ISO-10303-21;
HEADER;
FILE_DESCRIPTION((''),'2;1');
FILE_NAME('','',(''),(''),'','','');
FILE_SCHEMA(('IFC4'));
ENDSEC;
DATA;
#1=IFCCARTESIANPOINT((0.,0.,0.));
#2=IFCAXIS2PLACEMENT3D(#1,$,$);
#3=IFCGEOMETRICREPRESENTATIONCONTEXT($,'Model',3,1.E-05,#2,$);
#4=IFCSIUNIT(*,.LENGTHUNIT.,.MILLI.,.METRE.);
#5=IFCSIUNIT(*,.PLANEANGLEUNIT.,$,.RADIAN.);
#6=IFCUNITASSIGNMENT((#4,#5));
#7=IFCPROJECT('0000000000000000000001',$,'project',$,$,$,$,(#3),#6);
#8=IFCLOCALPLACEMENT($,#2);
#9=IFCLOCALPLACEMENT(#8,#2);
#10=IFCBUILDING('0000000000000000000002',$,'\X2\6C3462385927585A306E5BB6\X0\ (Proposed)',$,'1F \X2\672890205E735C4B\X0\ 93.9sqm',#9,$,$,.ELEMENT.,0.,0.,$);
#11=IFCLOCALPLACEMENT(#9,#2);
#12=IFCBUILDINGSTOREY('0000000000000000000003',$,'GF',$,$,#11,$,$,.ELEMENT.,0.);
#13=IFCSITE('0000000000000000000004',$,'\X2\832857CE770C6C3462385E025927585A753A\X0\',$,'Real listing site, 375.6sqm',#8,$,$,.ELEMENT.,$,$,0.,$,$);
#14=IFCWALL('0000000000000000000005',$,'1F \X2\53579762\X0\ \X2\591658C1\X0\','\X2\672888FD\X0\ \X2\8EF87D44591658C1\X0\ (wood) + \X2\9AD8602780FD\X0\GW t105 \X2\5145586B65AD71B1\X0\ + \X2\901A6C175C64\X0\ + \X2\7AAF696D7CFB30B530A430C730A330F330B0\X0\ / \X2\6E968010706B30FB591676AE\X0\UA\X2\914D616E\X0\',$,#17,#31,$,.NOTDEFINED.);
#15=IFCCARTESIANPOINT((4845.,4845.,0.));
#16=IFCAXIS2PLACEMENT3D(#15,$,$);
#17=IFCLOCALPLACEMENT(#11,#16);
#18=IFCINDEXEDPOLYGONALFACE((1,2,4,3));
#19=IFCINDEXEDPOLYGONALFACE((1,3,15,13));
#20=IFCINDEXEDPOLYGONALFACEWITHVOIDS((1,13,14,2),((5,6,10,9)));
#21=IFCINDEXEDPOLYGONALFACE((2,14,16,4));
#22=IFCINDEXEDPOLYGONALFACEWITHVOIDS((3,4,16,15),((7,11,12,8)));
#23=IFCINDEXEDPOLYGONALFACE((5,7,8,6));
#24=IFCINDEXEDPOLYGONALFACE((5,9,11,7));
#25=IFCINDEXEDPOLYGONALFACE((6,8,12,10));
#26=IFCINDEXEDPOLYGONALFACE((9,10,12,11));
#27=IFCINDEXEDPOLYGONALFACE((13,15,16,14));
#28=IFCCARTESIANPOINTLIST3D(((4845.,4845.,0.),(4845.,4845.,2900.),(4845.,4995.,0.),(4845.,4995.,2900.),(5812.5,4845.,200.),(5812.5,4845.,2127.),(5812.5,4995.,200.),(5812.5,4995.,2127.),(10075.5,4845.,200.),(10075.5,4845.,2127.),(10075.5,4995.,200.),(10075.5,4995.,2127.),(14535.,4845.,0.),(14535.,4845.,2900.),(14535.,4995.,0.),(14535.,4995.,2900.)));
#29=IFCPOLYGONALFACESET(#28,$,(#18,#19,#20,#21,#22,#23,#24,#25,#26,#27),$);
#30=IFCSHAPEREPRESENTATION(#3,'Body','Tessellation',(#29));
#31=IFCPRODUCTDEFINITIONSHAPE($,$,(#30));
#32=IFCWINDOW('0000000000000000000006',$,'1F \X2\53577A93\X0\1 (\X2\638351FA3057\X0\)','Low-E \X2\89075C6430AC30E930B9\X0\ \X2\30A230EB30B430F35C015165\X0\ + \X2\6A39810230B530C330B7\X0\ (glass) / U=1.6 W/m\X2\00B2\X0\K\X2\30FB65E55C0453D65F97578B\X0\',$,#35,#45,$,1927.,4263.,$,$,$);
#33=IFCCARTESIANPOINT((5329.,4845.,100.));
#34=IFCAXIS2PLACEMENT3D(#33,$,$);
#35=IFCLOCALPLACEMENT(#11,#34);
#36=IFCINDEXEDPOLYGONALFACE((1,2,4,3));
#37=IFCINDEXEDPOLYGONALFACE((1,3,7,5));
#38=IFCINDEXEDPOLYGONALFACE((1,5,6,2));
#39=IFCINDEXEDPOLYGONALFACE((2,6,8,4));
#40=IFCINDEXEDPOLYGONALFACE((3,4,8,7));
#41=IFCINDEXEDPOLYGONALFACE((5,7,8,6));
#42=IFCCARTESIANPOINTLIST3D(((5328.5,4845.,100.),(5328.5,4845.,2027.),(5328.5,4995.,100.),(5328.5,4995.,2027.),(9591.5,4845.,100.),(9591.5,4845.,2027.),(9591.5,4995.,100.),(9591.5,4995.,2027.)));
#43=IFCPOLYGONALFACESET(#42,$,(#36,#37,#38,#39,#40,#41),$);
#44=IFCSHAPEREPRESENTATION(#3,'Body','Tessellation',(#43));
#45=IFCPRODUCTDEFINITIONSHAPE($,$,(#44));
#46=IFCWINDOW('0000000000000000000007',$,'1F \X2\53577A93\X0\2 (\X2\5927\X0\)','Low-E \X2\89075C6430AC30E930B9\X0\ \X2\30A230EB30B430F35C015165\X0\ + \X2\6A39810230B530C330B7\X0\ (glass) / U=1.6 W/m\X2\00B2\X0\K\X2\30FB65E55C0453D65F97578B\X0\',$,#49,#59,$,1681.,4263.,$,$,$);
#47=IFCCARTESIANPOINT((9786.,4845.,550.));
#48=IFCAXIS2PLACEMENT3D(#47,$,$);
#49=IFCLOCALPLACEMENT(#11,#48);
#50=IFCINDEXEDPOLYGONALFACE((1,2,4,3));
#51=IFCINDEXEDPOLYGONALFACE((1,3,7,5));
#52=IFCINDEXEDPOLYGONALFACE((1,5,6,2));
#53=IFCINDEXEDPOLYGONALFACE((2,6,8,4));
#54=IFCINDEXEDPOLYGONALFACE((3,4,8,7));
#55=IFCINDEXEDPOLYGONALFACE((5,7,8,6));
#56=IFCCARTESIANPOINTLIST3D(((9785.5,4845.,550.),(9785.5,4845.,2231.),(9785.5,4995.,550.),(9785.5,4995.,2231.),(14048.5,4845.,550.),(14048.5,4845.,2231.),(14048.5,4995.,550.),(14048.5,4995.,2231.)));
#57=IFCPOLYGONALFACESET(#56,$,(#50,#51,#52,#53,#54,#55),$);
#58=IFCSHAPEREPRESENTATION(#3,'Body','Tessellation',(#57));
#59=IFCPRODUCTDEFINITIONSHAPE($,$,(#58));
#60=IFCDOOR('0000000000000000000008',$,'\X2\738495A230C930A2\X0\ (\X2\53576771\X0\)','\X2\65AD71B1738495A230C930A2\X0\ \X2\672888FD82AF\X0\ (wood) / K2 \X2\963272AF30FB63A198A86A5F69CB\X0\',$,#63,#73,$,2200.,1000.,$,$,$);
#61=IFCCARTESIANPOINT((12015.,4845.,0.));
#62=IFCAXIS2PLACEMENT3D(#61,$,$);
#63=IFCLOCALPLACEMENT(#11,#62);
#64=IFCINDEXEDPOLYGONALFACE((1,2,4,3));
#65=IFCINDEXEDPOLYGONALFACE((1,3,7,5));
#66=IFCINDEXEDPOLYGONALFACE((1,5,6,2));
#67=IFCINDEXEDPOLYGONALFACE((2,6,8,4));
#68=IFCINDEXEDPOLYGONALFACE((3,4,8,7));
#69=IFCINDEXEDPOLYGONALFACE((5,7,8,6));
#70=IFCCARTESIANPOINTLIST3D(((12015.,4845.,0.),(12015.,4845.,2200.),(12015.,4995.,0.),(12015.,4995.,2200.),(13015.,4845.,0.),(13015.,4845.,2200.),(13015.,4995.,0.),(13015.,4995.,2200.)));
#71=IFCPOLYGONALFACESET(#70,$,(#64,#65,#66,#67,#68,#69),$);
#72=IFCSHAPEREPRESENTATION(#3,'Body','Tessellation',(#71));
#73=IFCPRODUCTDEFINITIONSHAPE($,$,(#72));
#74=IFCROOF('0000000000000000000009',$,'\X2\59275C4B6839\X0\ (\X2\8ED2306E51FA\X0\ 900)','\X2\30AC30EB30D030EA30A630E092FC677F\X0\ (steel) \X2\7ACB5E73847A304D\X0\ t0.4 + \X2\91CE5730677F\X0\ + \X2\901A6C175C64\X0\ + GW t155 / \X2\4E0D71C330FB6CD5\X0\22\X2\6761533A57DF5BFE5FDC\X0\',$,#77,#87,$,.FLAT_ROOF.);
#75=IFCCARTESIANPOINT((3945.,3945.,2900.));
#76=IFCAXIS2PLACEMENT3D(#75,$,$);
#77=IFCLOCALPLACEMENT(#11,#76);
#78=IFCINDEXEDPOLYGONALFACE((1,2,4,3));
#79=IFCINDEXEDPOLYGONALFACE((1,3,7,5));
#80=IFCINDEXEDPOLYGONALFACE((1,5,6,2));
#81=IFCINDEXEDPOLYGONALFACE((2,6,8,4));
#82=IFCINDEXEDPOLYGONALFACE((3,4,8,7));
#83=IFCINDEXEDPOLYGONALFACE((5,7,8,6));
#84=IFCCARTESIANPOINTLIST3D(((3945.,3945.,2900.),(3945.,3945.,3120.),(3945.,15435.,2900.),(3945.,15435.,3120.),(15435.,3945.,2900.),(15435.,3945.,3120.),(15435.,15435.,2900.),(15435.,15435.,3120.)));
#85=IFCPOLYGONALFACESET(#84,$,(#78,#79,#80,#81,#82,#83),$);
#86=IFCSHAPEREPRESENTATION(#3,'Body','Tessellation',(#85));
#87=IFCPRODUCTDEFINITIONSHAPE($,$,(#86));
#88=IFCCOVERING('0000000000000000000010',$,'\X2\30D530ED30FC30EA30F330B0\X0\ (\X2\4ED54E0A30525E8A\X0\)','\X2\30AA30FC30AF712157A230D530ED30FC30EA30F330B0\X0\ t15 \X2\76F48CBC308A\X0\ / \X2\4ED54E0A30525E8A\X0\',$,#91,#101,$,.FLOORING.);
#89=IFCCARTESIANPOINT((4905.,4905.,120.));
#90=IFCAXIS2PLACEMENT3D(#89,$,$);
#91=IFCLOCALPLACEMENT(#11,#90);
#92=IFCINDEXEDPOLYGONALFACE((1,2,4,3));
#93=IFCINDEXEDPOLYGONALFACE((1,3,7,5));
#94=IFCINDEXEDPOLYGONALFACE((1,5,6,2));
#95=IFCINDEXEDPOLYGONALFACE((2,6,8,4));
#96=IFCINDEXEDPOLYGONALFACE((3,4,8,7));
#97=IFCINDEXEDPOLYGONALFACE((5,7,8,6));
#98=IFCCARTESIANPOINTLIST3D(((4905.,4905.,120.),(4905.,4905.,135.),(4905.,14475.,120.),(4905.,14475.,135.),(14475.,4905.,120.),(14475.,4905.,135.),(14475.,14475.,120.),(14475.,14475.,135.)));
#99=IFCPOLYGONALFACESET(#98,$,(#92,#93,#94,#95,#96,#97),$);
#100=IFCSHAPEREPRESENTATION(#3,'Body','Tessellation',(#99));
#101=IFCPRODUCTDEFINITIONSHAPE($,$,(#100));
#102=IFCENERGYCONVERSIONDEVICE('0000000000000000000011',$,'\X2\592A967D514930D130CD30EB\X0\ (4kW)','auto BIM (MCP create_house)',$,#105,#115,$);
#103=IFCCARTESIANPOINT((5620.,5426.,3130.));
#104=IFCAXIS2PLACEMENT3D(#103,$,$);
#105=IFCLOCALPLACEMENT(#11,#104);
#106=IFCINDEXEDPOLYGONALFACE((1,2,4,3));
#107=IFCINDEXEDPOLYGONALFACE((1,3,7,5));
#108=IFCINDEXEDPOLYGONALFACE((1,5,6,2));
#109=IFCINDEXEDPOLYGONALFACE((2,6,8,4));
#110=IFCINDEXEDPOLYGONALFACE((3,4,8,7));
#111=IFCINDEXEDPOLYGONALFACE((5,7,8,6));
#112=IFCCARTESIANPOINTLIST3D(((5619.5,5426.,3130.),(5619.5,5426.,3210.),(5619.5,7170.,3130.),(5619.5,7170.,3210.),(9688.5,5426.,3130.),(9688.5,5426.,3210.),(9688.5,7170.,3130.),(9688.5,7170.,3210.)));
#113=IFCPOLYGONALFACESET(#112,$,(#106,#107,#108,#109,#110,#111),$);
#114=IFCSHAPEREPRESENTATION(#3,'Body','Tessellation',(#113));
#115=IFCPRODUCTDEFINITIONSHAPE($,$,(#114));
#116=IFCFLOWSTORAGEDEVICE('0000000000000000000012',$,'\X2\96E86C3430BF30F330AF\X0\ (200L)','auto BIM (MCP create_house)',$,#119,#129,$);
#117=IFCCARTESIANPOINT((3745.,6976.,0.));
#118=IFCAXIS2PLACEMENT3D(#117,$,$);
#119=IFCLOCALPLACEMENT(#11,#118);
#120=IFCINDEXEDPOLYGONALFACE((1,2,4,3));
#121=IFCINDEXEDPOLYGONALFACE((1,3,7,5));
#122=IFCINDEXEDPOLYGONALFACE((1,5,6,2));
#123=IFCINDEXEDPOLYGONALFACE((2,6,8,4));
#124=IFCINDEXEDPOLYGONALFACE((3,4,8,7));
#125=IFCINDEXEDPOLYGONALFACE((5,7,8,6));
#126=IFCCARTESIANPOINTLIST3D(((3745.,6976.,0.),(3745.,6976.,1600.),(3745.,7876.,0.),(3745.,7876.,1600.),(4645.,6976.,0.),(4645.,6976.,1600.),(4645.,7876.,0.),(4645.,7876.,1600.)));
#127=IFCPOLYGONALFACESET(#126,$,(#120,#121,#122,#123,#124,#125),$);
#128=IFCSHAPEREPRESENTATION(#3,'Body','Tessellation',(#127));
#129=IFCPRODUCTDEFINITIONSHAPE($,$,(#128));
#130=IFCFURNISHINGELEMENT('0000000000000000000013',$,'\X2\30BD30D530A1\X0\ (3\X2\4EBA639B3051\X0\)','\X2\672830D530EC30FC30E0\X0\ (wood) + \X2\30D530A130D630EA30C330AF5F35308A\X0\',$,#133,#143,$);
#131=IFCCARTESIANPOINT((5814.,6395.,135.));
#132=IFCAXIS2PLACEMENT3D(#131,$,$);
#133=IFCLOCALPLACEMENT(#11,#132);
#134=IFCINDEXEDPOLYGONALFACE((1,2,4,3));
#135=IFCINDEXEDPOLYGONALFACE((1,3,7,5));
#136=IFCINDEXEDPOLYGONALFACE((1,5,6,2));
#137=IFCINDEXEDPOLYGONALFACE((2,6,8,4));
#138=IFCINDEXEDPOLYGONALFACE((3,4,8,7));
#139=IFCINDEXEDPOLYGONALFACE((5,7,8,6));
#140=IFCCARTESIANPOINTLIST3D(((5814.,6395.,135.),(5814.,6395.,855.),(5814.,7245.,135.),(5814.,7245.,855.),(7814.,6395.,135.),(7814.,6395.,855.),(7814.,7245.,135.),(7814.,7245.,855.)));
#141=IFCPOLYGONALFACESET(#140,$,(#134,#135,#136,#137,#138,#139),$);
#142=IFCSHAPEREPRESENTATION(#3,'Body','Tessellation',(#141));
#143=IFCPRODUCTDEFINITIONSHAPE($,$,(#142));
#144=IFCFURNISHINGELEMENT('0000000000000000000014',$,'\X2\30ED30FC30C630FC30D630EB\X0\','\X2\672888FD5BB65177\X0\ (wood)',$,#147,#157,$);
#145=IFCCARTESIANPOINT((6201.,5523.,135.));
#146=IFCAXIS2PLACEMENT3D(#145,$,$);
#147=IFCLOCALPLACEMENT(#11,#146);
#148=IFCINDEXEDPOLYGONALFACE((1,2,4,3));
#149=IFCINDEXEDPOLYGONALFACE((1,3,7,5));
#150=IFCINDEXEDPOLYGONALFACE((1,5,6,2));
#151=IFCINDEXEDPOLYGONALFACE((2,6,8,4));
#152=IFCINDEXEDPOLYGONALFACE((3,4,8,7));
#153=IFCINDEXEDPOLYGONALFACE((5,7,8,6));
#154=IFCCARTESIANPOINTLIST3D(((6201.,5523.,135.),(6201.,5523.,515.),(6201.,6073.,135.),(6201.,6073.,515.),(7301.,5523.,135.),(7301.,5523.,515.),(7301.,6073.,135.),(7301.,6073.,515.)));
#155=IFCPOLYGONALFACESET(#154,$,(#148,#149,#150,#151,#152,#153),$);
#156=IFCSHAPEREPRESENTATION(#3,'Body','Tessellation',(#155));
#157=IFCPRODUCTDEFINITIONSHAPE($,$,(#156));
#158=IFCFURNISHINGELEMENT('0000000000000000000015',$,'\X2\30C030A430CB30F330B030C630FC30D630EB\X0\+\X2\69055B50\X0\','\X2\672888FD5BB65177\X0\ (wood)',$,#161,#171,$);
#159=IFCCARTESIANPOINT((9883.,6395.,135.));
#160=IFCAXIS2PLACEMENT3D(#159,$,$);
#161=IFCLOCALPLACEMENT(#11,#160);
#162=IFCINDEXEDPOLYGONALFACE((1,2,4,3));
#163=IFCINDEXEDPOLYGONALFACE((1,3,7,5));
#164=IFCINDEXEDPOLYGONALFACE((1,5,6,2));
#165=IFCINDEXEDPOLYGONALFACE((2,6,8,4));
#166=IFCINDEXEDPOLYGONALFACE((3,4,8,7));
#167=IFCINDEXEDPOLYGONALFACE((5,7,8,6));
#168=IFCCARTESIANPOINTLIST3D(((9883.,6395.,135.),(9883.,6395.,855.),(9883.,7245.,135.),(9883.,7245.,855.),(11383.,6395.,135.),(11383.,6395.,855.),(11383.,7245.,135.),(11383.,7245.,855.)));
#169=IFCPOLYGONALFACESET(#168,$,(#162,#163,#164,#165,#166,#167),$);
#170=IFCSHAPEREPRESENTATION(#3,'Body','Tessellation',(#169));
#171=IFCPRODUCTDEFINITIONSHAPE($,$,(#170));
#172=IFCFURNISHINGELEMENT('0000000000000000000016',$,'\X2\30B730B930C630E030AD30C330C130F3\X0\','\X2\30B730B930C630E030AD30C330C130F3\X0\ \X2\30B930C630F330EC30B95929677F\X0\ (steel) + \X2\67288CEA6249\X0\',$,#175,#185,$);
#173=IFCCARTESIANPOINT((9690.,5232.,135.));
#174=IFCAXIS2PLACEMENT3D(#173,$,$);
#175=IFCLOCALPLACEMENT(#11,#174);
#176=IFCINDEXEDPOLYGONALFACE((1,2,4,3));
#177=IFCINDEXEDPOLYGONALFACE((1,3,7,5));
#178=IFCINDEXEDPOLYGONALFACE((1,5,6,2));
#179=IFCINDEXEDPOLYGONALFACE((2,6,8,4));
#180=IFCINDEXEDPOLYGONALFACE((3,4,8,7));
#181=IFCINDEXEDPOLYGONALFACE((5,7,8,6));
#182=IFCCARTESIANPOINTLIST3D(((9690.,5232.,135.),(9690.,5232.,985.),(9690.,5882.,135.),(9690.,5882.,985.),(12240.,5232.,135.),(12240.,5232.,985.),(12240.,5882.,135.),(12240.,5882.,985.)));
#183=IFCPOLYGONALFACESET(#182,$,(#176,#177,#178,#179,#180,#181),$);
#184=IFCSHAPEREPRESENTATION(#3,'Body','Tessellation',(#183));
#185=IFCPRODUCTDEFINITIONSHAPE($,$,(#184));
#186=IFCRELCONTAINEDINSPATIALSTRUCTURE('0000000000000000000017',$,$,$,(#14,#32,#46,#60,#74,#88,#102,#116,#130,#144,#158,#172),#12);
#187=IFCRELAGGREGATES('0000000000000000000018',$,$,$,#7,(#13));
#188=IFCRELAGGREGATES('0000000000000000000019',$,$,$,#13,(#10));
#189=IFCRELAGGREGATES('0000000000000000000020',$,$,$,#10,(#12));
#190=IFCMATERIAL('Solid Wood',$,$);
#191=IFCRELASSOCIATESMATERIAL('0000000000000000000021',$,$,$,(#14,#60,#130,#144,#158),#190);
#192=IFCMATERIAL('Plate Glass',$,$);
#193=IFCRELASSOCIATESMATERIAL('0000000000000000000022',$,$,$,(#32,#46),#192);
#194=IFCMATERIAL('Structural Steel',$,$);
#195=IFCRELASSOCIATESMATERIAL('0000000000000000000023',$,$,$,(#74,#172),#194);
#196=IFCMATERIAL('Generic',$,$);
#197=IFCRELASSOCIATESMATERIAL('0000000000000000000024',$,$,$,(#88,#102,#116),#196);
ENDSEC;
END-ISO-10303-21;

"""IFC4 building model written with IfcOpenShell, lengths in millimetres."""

from ifc_helpers import new_model, si_unit, frame, frame_2d, origin, place, context, project, spatial, rectangle, extrude, material, element, fill, save


model = new_model("IFC4")

# Units and contexts
model_context = context("Model", 3, precision=1e-05, world=origin())
ifc_project = project(units=[si_unit("LENGTHUNIT", "METRE", prefix="MILLI"), si_unit("PLANEANGLEUNIT", "RADIAN")], contexts=[model_context])

# Site, building, storey
site_placement = place(None, origin())
site = spatial("IfcSite", under=ifc_project, at=site_placement, Name="茨城県水戸市大塚町", ObjectType="Real listing site, 375.6sqm", CompositionType="ELEMENT", RefElevation=0.0)
building_placement = place(site_placement, origin())
building = spatial("IfcBuilding", under=site, at=building_placement, Name="水戸大塚の家 (Proposed)", ObjectType="1F 木造平屋 93.9sqm", CompositionType="ELEMENT", ElevationOfRefHeight=0.0, ElevationOfTerrain=0.0)
storey_placement = place(building_placement, origin())
storey = spatial("IfcBuildingStorey", under=building, at=storey_placement, Name="GF", CompositionType="ELEMENT", Elevation=0.0)

# Shared definitions
ifc_material_1 = material(Name="Solid Wood")

# Wall, openings, windows, door
wall_1_placement = place(storey_placement, frame((4845.0, 4845.0, 0.0)))
wall_1 = element("IfcWall", 1, at=wall_1_placement, inside=storey, material=ifc_material_1, Name="1F 南面 外壁", Description="木製 軸組外壁 (wood) + 高性能GW t105 充填断熱 + 通気層 + 窯業系サイディング / 準耐火・外皮UA配慮", PredefinedType="NOTDEFINED", context=model_context, shape_type="SweptSolid", body=[
    extrude(rectangle(XDim=9690.0, YDim=150.0, at=frame_2d((4845.0, 75.0))), frame((4845.0, 4845.0, 0.0)), (0.0, 0.0, 1.0), 2900.0),
])
opening_1_placement = place(storey_placement, frame((5329.0, 4845.0, 100.0)))
opening_1 = element("IfcOpeningElement", 2, at=opening_1_placement, cuts=wall_1, PredefinedType="NOTDEFINED", context=model_context, shape_type="SweptSolid", body=[
    extrude(rectangle(XDim=4263.0, YDim=150.0, at=frame_2d((2131.0, 75.0))), frame((5329.0, 4845.0, 100.0)), (0.0, 0.0, 1.0), 1927.0),
])
opening_2_placement = place(storey_placement, frame((9786.0, 4845.0, 550.0)))
opening_2 = element("IfcOpeningElement", 3, at=opening_2_placement, cuts=wall_1, PredefinedType="NOTDEFINED", context=model_context, shape_type="SweptSolid", body=[
    extrude(rectangle(XDim=4263.0, YDim=150.0, at=frame_2d((2131.0, 75.0))), frame((9786.0, 4845.0, 550.0)), (0.0, 0.0, 1.0), 1681.0),
])
opening_3_placement = place(storey_placement, frame((12015.0, 4845.0, 0.0)))
opening_3 = element("IfcOpeningElement", 4, at=opening_3_placement, cuts=wall_1, PredefinedType="NOTDEFINED", context=model_context, shape_type="SweptSolid", body=[
    extrude(rectangle(XDim=1000.0, YDim=150.0, at=frame_2d((500.0, 75.0))), frame((12015.0, 4845.0, 0.0)), (0.0, 0.0, 1.0), 2200.0),
])
ifc_material_2 = material(Name="Plate Glass")
window_1_placement = place(storey_placement, frame((5329.0, 4845.0, 100.0)))
window_1 = element("IfcWindow", 5, at=window_1_placement, inside=storey, material=ifc_material_2, Name="1F 南窓1 (掃出し)", Description="Low-E 複層ガラス アルゴン封入 + 樹脂サッシ (glass) / U=1.6 W/m²K・日射取得型", OverallHeight=1927.0, OverallWidth=4263.0, context=model_context, shape_type="SweptSolid", body=[
    extrude(rectangle(XDim=4263.0, YDim=150.0, at=frame_2d((2131.0, 75.0))), frame((5329.0, 4845.0, 100.0)), (0.0, 0.0, 1.0), 1927.0),
])
fill(opening_1, window_1)
window_2_placement = place(storey_placement, frame((9786.0, 4845.0, 550.0)))
window_2 = element("IfcWindow", 6, at=window_2_placement, inside=storey, material=ifc_material_2, Name="1F 南窓2 (大)", Description="Low-E 複層ガラス アルゴン封入 + 樹脂サッシ (glass) / U=1.6 W/m²K・日射取得型", OverallHeight=1681.0, OverallWidth=4263.0, context=model_context, shape_type="SweptSolid", body=[
    extrude(rectangle(XDim=4263.0, YDim=150.0, at=frame_2d((2131.0, 75.0))), frame((9786.0, 4845.0, 550.0)), (0.0, 0.0, 1.0), 1681.0),
])
fill(opening_2, window_2)
door_placement = place(storey_placement, frame((12015.0, 4845.0, 0.0)))
door = element("IfcDoor", 7, at=door_placement, inside=storey, material=ifc_material_1, Name="玄関ドア (南東)", Description="断熱玄関ドア 木製芯 (wood) / K2 防犯・採風機構", OverallHeight=2200.0, OverallWidth=1000.0, context=model_context, shape_type="SweptSolid", body=[
    extrude(rectangle(XDim=1000.0, YDim=150.0, at=frame_2d((500.0, 75.0))), frame((12015.0, 4845.0, 0.0)), (0.0, 0.0, 1.0), 2200.0),
])
fill(opening_3, door)

# Roof
ifc_material_3 = material(Name="Structural Steel")
roof_placement = place(storey_placement, frame((3945.0, 3945.0, 2900.0)))
element("IfcRoof", 8, at=roof_placement, inside=storey, material=ifc_material_3, Name="大屋根 (軒の出 900)", Description="ガルバリウム鋼板 (steel) 立平葺き t0.4 + 野地板 + 通気層 + GW t155 / 不燃・法22条区域対応", PredefinedType="FLAT_ROOF", context=model_context, shape_type="SweptSolid", body=[
    extrude(rectangle(XDim=11490.0, YDim=11490.0, at=frame_2d((5745.0, 5745.0))), frame((3945.0, 3945.0, 2900.0)), (0.0, 0.0, 1.0), 220.0),
])

# Covering
ifc_material_4 = material(Name="Generic")
covering_placement = place(storey_placement, frame((4905.0, 4905.0, 120.0)))
element("IfcCovering", 9, at=covering_placement, inside=storey, material=ifc_material_4, Name="フローリング (仕上げ床)", Description="オーク無垢フローリング t15 直貼り / 仕上げ床", PredefinedType="FLOORING", context=model_context, shape_type="SweptSolid", body=[
    extrude(rectangle(XDim=9570.0, YDim=9570.0, at=frame_2d((4785.0, 4785.0))), frame((4905.0, 4905.0, 120.0)), (0.0, 0.0, 1.0), 15.0),
])

# Energy conversion device
energy_conversion_device_placement = place(storey_placement, frame((5620.0, 5426.0, 3130.0)))
element("IfcEnergyConversionDevice", 10, at=energy_conversion_device_placement, inside=storey, material=ifc_material_4, Name="太陽光パネル (4kW)", Description="auto BIM (MCP create_house)", context=model_context, shape_type="SweptSolid", body=[
    extrude(rectangle(XDim=4069.0, YDim=1744.0, at=frame_2d((2034.0, 872.0))), frame((5620.0, 5426.0, 3130.0)), (0.0, 0.0, 1.0), 80.0),
])

# Flow storage device
flow_storage_device_placement = place(storey_placement, frame((3745.0, 6976.0, 0.0)))
element("IfcFlowStorageDevice", 11, at=flow_storage_device_placement, inside=storey, material=ifc_material_4, Name="雨水タンク (200L)", Description="auto BIM (MCP create_house)", context=model_context, shape_type="SweptSolid", body=[
    extrude(rectangle(XDim=900.0, YDim=900.0, at=frame_2d((450.0, 450.0))), frame((3745.0, 6976.0, 0.0)), (0.0, 0.0, 1.0), 1600.0),
])

# Furnishing elements
furnishing_1_placement = place(storey_placement, frame((5814.0, 6395.0, 135.0)))
element("IfcFurnishingElement", 12, at=furnishing_1_placement, inside=storey, material=ifc_material_1, Name="ソファ (3人掛け)", Description="木フレーム (wood) + ファブリック張り", context=model_context, shape_type="SweptSolid", body=[
    extrude(rectangle(XDim=2000.0, YDim=850.0, at=frame_2d((1000.0, 425.0))), frame((5814.0, 6395.0, 135.0)), (0.0, 0.0, 1.0), 720.0),
])
furnishing_2_placement = place(storey_placement, frame((6201.0, 5523.0, 135.0)))
element("IfcFurnishingElement", 13, at=furnishing_2_placement, inside=storey, material=ifc_material_1, Name="ローテーブル", Description="木製家具 (wood)", context=model_context, shape_type="SweptSolid", body=[
    extrude(rectangle(XDim=1100.0, YDim=550.0, at=frame_2d((550.0, 275.0))), frame((6201.0, 5523.0, 135.0)), (0.0, 0.0, 1.0), 380.0),
])
furnishing_3_placement = place(storey_placement, frame((9883.0, 6395.0, 135.0)))
element("IfcFurnishingElement", 14, at=furnishing_3_placement, inside=storey, material=ifc_material_1, Name="ダイニングテーブル+椅子", Description="木製家具 (wood)", context=model_context, shape_type="SweptSolid", body=[
    extrude(rectangle(XDim=1500.0, YDim=850.0, at=frame_2d((750.0, 425.0))), frame((9883.0, 6395.0, 135.0)), (0.0, 0.0, 1.0), 720.0),
])
furnishing_4_placement = place(storey_placement, frame((9690.0, 5232.0, 135.0)))
element("IfcFurnishingElement", 15, at=furnishing_4_placement, inside=storey, material=ifc_material_3, Name="システムキッチン", Description="システムキッチン ステンレス天板 (steel) + 木質扉", context=model_context, shape_type="SweptSolid", body=[
    extrude(rectangle(XDim=2550.0, YDim=650.0, at=frame_2d((1275.0, 325.0))), frame((9690.0, 5232.0, 135.0)), (0.0, 0.0, 1.0), 850.0),
])

save(model, "model.ifc")
